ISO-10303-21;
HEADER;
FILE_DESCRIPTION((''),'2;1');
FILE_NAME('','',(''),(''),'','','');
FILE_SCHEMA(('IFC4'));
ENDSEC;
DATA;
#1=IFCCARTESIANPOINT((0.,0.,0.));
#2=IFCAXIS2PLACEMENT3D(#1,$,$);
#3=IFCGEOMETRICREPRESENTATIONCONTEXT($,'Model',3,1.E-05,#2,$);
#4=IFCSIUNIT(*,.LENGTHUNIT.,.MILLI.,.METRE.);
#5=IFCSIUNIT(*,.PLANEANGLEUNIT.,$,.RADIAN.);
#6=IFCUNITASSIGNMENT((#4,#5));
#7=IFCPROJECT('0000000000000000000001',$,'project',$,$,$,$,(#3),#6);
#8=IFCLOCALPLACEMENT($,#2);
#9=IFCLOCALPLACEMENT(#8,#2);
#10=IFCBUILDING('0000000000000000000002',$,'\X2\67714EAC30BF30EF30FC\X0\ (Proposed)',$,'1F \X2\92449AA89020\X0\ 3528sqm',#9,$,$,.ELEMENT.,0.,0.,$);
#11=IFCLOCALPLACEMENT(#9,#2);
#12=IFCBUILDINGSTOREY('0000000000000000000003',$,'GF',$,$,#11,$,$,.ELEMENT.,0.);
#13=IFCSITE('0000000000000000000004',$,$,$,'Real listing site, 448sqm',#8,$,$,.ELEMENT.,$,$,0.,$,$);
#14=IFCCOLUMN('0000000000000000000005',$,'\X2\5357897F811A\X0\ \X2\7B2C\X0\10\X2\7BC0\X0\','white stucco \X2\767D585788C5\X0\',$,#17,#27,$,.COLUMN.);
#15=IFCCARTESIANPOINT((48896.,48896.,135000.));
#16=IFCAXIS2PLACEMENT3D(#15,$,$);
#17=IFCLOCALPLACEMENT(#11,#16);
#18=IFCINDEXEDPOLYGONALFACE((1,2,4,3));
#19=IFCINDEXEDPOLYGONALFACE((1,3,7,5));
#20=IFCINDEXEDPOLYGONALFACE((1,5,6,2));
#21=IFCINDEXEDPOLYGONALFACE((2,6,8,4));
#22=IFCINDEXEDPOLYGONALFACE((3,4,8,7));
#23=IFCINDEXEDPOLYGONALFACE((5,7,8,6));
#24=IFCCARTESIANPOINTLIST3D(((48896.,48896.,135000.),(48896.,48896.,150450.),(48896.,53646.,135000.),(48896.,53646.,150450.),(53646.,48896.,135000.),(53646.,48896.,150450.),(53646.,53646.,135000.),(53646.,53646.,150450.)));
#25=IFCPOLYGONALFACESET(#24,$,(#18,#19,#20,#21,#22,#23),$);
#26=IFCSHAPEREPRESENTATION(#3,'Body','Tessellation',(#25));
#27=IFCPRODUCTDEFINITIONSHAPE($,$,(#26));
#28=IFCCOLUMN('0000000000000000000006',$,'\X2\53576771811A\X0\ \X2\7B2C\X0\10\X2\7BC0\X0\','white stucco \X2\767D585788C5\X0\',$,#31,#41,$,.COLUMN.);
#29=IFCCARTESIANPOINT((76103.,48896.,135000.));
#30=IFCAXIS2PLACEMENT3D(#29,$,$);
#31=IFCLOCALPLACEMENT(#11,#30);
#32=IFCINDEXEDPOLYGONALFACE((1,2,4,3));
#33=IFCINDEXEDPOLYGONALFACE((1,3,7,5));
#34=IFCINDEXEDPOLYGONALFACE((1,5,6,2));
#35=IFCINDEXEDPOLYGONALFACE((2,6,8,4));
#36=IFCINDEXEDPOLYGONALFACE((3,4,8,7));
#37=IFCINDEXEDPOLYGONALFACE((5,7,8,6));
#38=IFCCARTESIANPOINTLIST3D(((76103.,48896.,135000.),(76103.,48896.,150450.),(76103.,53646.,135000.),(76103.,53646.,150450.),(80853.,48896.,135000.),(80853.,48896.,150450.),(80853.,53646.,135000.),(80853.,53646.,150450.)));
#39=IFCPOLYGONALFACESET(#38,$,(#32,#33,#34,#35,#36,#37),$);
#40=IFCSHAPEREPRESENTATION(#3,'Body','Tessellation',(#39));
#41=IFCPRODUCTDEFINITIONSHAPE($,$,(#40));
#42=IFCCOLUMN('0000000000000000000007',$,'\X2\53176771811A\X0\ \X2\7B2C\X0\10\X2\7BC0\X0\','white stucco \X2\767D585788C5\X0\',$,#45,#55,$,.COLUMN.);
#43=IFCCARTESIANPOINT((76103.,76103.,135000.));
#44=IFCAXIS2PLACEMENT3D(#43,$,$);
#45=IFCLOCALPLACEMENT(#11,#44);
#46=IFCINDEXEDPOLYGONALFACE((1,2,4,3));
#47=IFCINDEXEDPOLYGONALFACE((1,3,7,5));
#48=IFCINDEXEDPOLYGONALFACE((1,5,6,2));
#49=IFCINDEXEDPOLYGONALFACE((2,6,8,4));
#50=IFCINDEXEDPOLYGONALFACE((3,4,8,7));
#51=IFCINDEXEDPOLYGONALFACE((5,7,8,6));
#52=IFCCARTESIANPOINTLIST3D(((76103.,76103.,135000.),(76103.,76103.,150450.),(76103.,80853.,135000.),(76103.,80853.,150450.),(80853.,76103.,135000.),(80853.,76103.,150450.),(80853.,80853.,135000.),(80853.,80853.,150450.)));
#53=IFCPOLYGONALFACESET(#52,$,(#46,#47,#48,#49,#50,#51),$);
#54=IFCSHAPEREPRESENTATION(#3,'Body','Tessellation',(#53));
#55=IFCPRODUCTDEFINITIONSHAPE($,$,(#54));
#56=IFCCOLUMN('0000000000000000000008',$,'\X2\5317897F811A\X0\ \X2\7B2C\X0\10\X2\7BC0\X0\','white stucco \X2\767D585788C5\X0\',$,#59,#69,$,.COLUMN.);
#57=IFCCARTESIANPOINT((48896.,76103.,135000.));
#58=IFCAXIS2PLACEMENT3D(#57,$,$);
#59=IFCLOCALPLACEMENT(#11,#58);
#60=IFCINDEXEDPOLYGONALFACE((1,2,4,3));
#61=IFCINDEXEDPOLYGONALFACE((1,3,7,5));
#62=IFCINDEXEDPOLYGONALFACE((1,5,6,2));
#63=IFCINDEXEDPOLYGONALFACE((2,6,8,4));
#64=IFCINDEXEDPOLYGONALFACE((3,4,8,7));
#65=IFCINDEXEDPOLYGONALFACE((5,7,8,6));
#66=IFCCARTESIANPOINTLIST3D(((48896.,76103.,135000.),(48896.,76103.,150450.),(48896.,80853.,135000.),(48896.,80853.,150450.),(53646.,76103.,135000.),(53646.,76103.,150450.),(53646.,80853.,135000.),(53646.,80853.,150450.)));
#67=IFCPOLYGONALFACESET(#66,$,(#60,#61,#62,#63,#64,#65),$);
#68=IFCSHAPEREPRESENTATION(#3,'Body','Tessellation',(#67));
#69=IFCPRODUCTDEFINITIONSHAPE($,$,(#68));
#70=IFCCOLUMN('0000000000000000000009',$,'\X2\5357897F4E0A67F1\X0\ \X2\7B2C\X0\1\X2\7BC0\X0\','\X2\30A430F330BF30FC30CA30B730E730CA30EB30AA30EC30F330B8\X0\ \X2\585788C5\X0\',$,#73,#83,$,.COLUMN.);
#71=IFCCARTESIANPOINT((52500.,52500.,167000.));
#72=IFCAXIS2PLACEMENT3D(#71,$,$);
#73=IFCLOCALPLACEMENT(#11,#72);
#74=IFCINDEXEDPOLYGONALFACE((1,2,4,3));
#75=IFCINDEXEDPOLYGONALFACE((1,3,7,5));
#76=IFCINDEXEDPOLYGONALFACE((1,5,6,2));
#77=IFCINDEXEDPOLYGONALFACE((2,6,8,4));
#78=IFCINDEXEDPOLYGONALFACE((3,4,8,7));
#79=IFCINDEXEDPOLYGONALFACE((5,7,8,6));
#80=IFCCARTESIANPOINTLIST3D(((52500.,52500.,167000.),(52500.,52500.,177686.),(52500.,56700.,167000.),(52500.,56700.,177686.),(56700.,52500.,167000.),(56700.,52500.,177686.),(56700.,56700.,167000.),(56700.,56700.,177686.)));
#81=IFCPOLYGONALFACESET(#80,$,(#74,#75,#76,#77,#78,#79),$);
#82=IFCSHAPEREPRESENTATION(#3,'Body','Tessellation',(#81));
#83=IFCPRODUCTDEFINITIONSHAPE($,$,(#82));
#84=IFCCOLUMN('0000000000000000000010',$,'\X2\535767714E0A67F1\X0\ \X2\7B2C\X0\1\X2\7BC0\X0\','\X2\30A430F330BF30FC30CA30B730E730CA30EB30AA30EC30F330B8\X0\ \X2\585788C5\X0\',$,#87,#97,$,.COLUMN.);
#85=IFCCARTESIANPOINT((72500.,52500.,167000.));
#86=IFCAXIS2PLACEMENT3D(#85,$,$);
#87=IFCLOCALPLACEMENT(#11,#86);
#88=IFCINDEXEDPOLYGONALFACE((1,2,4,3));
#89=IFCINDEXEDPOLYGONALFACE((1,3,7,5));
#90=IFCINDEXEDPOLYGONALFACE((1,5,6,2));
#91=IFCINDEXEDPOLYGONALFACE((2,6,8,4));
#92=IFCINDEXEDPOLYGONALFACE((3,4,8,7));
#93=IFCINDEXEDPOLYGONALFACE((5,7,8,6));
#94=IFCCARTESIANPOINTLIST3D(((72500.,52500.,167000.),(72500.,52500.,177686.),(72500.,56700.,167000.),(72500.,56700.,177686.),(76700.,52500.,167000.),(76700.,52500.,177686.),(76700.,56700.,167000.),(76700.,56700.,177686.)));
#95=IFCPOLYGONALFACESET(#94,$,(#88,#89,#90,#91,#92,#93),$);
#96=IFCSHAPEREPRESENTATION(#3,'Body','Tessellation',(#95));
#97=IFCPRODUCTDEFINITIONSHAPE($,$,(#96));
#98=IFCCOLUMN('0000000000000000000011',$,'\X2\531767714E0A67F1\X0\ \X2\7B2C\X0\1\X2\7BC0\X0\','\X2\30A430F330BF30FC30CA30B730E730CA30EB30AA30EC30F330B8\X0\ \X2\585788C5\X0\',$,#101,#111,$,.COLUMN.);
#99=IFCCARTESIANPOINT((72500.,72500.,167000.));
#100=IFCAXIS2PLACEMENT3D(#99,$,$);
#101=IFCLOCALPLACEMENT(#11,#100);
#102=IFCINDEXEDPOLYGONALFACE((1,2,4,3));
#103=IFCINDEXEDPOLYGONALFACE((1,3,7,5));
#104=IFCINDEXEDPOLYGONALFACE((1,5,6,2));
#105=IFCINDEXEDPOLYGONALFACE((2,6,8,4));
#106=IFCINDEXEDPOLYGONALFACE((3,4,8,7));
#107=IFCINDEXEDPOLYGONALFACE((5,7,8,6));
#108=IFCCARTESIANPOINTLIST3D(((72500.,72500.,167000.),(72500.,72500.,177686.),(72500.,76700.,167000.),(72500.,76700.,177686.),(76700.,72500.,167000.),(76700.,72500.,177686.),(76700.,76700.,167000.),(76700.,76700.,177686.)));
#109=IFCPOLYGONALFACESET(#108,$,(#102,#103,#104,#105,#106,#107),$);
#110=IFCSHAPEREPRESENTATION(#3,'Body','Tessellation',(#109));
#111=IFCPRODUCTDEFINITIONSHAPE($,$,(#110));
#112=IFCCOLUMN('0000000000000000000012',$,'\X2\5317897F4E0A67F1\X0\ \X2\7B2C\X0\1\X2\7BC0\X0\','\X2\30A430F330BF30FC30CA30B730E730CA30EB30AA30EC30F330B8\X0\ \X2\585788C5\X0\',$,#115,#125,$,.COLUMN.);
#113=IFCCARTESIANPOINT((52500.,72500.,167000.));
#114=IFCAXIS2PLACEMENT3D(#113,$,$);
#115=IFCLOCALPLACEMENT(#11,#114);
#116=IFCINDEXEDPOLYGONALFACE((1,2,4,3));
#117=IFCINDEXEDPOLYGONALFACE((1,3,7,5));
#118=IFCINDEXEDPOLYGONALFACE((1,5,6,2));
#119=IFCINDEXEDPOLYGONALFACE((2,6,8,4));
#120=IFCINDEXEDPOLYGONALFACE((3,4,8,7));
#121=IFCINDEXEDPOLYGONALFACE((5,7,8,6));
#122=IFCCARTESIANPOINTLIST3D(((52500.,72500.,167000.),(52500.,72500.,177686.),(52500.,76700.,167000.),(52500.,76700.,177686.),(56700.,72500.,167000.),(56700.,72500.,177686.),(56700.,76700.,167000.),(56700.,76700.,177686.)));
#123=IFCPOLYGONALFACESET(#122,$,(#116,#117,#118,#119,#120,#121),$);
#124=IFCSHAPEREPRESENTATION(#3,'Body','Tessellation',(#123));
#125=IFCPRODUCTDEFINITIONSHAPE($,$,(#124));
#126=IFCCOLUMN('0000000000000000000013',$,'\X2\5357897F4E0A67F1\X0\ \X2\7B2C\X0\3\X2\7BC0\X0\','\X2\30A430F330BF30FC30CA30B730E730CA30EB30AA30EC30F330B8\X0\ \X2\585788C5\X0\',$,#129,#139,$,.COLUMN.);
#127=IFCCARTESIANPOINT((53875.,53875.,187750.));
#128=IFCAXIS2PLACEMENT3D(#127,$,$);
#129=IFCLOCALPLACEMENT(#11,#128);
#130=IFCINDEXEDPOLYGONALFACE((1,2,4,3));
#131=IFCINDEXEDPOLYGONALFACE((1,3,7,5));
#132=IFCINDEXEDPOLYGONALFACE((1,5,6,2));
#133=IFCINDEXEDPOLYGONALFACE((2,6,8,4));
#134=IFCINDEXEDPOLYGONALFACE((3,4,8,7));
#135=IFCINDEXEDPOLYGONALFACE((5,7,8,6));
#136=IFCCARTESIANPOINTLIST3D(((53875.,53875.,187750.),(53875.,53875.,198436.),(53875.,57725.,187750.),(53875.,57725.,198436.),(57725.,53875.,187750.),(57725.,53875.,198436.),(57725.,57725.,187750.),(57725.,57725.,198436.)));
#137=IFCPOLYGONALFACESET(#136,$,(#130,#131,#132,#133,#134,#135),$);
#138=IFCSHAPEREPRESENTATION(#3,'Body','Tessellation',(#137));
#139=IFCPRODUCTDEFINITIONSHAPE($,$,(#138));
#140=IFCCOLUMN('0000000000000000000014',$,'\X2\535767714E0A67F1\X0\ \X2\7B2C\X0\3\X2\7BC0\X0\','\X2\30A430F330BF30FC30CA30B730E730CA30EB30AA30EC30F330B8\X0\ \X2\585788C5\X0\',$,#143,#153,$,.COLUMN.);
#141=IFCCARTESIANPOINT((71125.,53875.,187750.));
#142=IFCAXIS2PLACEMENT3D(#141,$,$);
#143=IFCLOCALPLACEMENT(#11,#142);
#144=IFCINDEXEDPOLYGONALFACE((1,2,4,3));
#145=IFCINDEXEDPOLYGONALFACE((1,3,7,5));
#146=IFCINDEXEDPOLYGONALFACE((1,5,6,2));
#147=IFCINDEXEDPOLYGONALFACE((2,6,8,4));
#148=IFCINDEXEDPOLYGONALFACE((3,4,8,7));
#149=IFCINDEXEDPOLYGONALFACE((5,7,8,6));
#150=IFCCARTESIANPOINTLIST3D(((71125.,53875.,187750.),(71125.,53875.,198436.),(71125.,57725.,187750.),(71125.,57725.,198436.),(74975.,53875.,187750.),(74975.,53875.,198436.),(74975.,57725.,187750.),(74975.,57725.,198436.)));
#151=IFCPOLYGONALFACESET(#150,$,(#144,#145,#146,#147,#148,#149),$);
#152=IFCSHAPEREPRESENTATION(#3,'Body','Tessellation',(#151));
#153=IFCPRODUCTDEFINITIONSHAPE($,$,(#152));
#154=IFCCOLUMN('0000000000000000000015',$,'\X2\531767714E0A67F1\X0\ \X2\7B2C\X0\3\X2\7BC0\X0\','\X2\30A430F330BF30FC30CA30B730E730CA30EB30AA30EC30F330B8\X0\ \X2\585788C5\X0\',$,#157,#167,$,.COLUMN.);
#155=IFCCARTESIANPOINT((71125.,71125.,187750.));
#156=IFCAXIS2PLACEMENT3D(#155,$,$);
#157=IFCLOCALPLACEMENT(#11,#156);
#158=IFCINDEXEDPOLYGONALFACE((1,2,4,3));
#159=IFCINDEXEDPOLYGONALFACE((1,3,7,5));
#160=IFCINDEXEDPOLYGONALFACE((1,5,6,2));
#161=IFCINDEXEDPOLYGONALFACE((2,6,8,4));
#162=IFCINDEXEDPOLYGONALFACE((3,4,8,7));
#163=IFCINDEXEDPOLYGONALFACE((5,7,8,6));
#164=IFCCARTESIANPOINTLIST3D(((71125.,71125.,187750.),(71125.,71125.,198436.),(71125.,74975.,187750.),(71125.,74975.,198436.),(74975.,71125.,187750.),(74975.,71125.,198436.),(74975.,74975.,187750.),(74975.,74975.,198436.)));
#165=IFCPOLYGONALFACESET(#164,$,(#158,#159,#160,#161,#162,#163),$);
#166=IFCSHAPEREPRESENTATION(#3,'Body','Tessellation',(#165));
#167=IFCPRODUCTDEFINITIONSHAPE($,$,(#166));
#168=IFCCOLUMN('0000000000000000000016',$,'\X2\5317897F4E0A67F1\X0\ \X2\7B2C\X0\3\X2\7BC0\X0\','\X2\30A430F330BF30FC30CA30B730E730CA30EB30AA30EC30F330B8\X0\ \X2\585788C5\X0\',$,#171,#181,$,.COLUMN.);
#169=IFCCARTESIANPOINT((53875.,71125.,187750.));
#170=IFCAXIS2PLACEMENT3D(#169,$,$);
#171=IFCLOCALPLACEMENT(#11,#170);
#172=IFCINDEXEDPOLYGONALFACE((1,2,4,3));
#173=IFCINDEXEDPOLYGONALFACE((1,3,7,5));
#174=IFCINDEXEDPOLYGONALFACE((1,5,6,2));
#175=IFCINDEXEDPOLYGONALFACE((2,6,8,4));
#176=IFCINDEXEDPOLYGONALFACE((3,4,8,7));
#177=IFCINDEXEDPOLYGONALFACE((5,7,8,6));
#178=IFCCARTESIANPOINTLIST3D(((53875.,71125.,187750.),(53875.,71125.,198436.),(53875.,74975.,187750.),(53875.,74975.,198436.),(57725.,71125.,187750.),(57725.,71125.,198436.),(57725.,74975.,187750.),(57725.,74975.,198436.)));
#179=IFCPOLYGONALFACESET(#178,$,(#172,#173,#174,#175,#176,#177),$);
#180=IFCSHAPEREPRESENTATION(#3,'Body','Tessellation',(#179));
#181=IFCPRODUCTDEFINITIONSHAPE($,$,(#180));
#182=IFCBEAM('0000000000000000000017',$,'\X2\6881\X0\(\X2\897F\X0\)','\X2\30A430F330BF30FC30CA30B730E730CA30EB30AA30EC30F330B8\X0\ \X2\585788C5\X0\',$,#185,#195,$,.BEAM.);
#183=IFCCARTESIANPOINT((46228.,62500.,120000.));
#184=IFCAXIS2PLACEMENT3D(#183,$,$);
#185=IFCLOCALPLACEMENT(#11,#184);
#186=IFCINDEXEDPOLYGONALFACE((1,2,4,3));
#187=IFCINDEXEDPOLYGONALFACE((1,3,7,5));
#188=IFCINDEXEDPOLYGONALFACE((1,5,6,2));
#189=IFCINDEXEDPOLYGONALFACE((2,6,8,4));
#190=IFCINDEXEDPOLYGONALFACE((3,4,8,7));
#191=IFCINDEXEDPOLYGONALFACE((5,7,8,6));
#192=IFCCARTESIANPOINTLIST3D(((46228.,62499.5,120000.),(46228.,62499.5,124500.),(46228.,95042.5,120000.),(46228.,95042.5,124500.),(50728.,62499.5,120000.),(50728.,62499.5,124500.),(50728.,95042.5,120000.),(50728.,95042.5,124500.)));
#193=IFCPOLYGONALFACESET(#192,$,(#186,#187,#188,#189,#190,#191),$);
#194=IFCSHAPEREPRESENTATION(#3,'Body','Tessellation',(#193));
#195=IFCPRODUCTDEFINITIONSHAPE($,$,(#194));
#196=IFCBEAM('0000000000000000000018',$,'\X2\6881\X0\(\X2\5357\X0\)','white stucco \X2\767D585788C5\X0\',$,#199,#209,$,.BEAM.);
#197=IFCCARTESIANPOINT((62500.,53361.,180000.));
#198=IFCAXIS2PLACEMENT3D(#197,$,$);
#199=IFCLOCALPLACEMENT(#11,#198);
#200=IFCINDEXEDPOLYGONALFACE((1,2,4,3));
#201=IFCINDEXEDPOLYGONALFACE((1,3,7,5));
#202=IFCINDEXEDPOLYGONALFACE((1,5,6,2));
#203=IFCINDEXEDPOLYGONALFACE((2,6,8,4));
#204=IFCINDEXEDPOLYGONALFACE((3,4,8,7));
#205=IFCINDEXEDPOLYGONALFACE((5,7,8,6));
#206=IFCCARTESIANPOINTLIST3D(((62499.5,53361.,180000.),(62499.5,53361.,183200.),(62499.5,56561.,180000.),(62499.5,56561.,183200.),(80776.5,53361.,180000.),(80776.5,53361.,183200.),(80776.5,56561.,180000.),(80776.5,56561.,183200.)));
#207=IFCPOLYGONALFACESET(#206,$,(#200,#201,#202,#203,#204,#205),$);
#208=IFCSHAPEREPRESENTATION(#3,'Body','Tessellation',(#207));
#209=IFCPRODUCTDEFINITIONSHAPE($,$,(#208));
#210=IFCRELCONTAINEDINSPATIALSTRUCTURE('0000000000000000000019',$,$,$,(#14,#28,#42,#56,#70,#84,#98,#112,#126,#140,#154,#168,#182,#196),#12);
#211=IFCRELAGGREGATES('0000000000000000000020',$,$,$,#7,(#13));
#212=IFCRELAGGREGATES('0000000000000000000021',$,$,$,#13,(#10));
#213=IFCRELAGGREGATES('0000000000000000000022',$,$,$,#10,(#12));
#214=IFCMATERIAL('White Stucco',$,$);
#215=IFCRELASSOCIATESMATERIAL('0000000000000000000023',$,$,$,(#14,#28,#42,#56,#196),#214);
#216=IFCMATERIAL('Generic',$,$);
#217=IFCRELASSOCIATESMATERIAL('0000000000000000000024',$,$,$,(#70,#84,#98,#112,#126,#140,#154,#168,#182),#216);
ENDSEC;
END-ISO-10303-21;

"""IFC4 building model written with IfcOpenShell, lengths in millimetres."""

from ifc_helpers import new_model, si_unit, frame, frame_2d, origin, place, context, project, spatial, rectangle, extrude, material, element, save


model = new_model("IFC4")

# Units and contexts
model_context = context("Model", 3, precision=1e-05, world=origin())
ifc_project = project(units=[si_unit("LENGTHUNIT", "METRE", prefix="MILLI"), si_unit("PLANEANGLEUNIT", "RADIAN")], contexts=[model_context])

# Site, building, storey
site_placement = place(None, origin())
site = spatial("IfcSite", under=ifc_project, at=site_placement, ObjectType="Real listing site, 448sqm", CompositionType="ELEMENT", RefElevation=0.0)
building_placement = place(site_placement, origin())
building = spatial("IfcBuilding", under=site, at=building_placement, Name="東京タワー (Proposed)", ObjectType="1F 鉄骨造 3528sqm", CompositionType="ELEMENT", ElevationOfRefHeight=0.0, ElevationOfTerrain=0.0)
storey_placement = place(building_placement, origin())
storey = spatial("IfcBuildingStorey", under=building, at=storey_placement, Name="GF", CompositionType="ELEMENT", Elevation=0.0)

# Columns
ifc_material_1 = material(Name="White Stucco")
column_1_placement = place(storey_placement, frame((48896.0, 48896.0, 135000.0)))
element("IfcColumn", 1, at=column_1_placement, inside=storey, material=ifc_material_1, Name="南西脚 第10節", Description="white stucco 白塗装", PredefinedType="COLUMN", context=model_context, shape_type="SweptSolid", body=[
    extrude(rectangle(XDim=4750.0, YDim=4750.0, at=frame_2d((2375.0, 2375.0))), frame((48896.0, 48896.0, 135000.0)), (0.0, 0.0, 1.0), 15450.0),
])
column_2_placement = place(storey_placement, frame((76103.0, 48896.0, 135000.0)))
element("IfcColumn", 2, at=column_2_placement, inside=storey, material=ifc_material_1, Name="南東脚 第10節", Description="white stucco 白塗装", PredefinedType="COLUMN", context=model_context, shape_type="SweptSolid", body=[
    extrude(rectangle(XDim=4750.0, YDim=4750.0, at=frame_2d((2375.0, 2375.0))), frame((76103.0, 48896.0, 135000.0)), (0.0, 0.0, 1.0), 15450.0),
])
column_3_placement = place(storey_placement, frame((76103.0, 76103.0, 135000.0)))
element("IfcColumn", 3, at=column_3_placement, inside=storey, material=ifc_material_1, Name="北東脚 第10節", Description="white stucco 白塗装", PredefinedType="COLUMN", context=model_context, shape_type="SweptSolid", body=[
    extrude(rectangle(XDim=4750.0, YDim=4750.0, at=frame_2d((2375.0, 2375.0))), frame((76103.0, 76103.0, 135000.0)), (0.0, 0.0, 1.0), 15450.0),
])
column_4_placement = place(storey_placement, frame((48896.0, 76103.0, 135000.0)))
element("IfcColumn", 4, at=column_4_placement, inside=storey, material=ifc_material_1, Name="北西脚 第10節", Description="white stucco 白塗装", PredefinedType="COLUMN", context=model_context, shape_type="SweptSolid", body=[
    extrude(rectangle(XDim=4750.0, YDim=4750.0, at=frame_2d((2375.0, 2375.0))), frame((48896.0, 76103.0, 135000.0)), (0.0, 0.0, 1.0), 15450.0),
])
ifc_material_2 = material(Name="Generic")
column_5_placement = place(storey_placement, frame((52500.0, 52500.0, 167000.0)))
element("IfcColumn", 5, at=column_5_placement, inside=storey, material=ifc_material_2, Name="南西上柱 第1節", Description="インターナショナルオレンジ 塗装", PredefinedType="COLUMN", context=model_context, shape_type="SweptSolid", body=[
    extrude(rectangle(XDim=4200.0, YDim=4200.0, at=frame_2d((2100.0, 2100.0))), frame((52500.0, 52500.0, 167000.0)), (0.0, 0.0, 1.0), 10686.0),
])
column_6_placement = place(storey_placement, frame((72500.0, 52500.0, 167000.0)))
element("IfcColumn", 6, at=column_6_placement, inside=storey, material=ifc_material_2, Name="南東上柱 第1節", Description="インターナショナルオレンジ 塗装", PredefinedType="COLUMN", context=model_context, shape_type="SweptSolid", body=[
    extrude(rectangle(XDim=4200.0, YDim=4200.0, at=frame_2d((2100.0, 2100.0))), frame((72500.0, 52500.0, 167000.0)), (0.0, 0.0, 1.0), 10686.0),
])
column_7_placement = place(storey_placement, frame((72500.0, 72500.0, 167000.0)))
element("IfcColumn", 7, at=column_7_placement, inside=storey, material=ifc_material_2, Name="北東上柱 第1節", Description="インターナショナルオレンジ 塗装", PredefinedType="COLUMN", context=model_context, shape_type="SweptSolid", body=[
    extrude(rectangle(XDim=4200.0, YDim=4200.0, at=frame_2d((2100.0, 2100.0))), frame((72500.0, 72500.0, 167000.0)), (0.0, 0.0, 1.0), 10686.0),
])
column_8_placement = place(storey_placement, frame((52500.0, 72500.0, 167000.0)))
element("IfcColumn", 8, at=column_8_placement, inside=storey, material=ifc_material_2, Name="北西上柱 第1節", Description="インターナショナルオレンジ 塗装", PredefinedType="COLUMN", context=model_context, shape_type="SweptSolid", body=[
    extrude(rectangle(XDim=4200.0, YDim=4200.0, at=frame_2d((2100.0, 2100.0))), frame((52500.0, 72500.0, 167000.0)), (0.0, 0.0, 1.0), 10686.0),
])
column_9_placement = place(storey_placement, frame((53875.0, 53875.0, 187750.0)))
element("IfcColumn", 9, at=column_9_placement, inside=storey, material=ifc_material_2, Name="南西上柱 第3節", Description="インターナショナルオレンジ 塗装", PredefinedType="COLUMN", context=model_context, shape_type="SweptSolid", body=[
    extrude(rectangle(XDim=3850.0, YDim=3850.0, at=frame_2d((1925.0, 1925.0))), frame((53875.0, 53875.0, 187750.0)), (0.0, 0.0, 1.0), 10686.0),
])
column_10_placement = place(storey_placement, frame((71125.0, 53875.0, 187750.0)))
element("IfcColumn", 10, at=column_10_placement, inside=storey, material=ifc_material_2, Name="南東上柱 第3節", Description="インターナショナルオレンジ 塗装", PredefinedType="COLUMN", context=model_context, shape_type="SweptSolid", body=[
    extrude(rectangle(XDim=3850.0, YDim=3850.0, at=frame_2d((1925.0, 1925.0))), frame((71125.0, 53875.0, 187750.0)), (0.0, 0.0, 1.0), 10686.0),
])
column_11_placement = place(storey_placement, frame((71125.0, 71125.0, 187750.0)))
element("IfcColumn", 11, at=column_11_placement, inside=storey, material=ifc_material_2, Name="北東上柱 第3節", Description="インターナショナルオレンジ 塗装", PredefinedType="COLUMN", context=model_context, shape_type="SweptSolid", body=[
    extrude(rectangle(XDim=3850.0, YDim=3850.0, at=frame_2d((1925.0, 1925.0))), frame((71125.0, 71125.0, 187750.0)), (0.0, 0.0, 1.0), 10686.0),
])
column_12_placement = place(storey_placement, frame((53875.0, 71125.0, 187750.0)))
element("IfcColumn", 12, at=column_12_placement, inside=storey, material=ifc_material_2, Name="北西上柱 第3節", Description="インターナショナルオレンジ 塗装", PredefinedType="COLUMN", context=model_context, shape_type="SweptSolid", body=[
    extrude(rectangle(XDim=3850.0, YDim=3850.0, at=frame_2d((1925.0, 1925.0))), frame((53875.0, 71125.0, 187750.0)), (0.0, 0.0, 1.0), 10686.0),
])

# Beams
beam_1_placement = place(storey_placement, frame((46228.0, 62500.0, 120000.0)))
element("IfcBeam", 13, at=beam_1_placement, inside=storey, material=ifc_material_2, Name="梁(西)", Description="インターナショナルオレンジ 塗装", PredefinedType="BEAM", context=model_context, shape_type="SweptSolid", body=[
    extrude(rectangle(XDim=4500.0, YDim=32543.0, at=frame_2d((2250.0, 16271.0))), frame((46228.0, 62500.0, 120000.0)), (0.0, 0.0, 1.0), 4500.0),
])
beam_2_placement = place(storey_placement, frame((62500.0, 53361.0, 180000.0)))
element("IfcBeam", 14, at=beam_2_placement, inside=storey, material=ifc_material_1, Name="梁(南)", Description="white stucco 白塗装", PredefinedType="BEAM", context=model_context, shape_type="SweptSolid", body=[
    extrude(rectangle(XDim=18277.0, YDim=3200.0, at=frame_2d((9138.0, 1600.0))), frame((62500.0, 53361.0, 180000.0)), (0.0, 0.0, 1.0), 3200.0),
])

save(model, "model.ifc")
